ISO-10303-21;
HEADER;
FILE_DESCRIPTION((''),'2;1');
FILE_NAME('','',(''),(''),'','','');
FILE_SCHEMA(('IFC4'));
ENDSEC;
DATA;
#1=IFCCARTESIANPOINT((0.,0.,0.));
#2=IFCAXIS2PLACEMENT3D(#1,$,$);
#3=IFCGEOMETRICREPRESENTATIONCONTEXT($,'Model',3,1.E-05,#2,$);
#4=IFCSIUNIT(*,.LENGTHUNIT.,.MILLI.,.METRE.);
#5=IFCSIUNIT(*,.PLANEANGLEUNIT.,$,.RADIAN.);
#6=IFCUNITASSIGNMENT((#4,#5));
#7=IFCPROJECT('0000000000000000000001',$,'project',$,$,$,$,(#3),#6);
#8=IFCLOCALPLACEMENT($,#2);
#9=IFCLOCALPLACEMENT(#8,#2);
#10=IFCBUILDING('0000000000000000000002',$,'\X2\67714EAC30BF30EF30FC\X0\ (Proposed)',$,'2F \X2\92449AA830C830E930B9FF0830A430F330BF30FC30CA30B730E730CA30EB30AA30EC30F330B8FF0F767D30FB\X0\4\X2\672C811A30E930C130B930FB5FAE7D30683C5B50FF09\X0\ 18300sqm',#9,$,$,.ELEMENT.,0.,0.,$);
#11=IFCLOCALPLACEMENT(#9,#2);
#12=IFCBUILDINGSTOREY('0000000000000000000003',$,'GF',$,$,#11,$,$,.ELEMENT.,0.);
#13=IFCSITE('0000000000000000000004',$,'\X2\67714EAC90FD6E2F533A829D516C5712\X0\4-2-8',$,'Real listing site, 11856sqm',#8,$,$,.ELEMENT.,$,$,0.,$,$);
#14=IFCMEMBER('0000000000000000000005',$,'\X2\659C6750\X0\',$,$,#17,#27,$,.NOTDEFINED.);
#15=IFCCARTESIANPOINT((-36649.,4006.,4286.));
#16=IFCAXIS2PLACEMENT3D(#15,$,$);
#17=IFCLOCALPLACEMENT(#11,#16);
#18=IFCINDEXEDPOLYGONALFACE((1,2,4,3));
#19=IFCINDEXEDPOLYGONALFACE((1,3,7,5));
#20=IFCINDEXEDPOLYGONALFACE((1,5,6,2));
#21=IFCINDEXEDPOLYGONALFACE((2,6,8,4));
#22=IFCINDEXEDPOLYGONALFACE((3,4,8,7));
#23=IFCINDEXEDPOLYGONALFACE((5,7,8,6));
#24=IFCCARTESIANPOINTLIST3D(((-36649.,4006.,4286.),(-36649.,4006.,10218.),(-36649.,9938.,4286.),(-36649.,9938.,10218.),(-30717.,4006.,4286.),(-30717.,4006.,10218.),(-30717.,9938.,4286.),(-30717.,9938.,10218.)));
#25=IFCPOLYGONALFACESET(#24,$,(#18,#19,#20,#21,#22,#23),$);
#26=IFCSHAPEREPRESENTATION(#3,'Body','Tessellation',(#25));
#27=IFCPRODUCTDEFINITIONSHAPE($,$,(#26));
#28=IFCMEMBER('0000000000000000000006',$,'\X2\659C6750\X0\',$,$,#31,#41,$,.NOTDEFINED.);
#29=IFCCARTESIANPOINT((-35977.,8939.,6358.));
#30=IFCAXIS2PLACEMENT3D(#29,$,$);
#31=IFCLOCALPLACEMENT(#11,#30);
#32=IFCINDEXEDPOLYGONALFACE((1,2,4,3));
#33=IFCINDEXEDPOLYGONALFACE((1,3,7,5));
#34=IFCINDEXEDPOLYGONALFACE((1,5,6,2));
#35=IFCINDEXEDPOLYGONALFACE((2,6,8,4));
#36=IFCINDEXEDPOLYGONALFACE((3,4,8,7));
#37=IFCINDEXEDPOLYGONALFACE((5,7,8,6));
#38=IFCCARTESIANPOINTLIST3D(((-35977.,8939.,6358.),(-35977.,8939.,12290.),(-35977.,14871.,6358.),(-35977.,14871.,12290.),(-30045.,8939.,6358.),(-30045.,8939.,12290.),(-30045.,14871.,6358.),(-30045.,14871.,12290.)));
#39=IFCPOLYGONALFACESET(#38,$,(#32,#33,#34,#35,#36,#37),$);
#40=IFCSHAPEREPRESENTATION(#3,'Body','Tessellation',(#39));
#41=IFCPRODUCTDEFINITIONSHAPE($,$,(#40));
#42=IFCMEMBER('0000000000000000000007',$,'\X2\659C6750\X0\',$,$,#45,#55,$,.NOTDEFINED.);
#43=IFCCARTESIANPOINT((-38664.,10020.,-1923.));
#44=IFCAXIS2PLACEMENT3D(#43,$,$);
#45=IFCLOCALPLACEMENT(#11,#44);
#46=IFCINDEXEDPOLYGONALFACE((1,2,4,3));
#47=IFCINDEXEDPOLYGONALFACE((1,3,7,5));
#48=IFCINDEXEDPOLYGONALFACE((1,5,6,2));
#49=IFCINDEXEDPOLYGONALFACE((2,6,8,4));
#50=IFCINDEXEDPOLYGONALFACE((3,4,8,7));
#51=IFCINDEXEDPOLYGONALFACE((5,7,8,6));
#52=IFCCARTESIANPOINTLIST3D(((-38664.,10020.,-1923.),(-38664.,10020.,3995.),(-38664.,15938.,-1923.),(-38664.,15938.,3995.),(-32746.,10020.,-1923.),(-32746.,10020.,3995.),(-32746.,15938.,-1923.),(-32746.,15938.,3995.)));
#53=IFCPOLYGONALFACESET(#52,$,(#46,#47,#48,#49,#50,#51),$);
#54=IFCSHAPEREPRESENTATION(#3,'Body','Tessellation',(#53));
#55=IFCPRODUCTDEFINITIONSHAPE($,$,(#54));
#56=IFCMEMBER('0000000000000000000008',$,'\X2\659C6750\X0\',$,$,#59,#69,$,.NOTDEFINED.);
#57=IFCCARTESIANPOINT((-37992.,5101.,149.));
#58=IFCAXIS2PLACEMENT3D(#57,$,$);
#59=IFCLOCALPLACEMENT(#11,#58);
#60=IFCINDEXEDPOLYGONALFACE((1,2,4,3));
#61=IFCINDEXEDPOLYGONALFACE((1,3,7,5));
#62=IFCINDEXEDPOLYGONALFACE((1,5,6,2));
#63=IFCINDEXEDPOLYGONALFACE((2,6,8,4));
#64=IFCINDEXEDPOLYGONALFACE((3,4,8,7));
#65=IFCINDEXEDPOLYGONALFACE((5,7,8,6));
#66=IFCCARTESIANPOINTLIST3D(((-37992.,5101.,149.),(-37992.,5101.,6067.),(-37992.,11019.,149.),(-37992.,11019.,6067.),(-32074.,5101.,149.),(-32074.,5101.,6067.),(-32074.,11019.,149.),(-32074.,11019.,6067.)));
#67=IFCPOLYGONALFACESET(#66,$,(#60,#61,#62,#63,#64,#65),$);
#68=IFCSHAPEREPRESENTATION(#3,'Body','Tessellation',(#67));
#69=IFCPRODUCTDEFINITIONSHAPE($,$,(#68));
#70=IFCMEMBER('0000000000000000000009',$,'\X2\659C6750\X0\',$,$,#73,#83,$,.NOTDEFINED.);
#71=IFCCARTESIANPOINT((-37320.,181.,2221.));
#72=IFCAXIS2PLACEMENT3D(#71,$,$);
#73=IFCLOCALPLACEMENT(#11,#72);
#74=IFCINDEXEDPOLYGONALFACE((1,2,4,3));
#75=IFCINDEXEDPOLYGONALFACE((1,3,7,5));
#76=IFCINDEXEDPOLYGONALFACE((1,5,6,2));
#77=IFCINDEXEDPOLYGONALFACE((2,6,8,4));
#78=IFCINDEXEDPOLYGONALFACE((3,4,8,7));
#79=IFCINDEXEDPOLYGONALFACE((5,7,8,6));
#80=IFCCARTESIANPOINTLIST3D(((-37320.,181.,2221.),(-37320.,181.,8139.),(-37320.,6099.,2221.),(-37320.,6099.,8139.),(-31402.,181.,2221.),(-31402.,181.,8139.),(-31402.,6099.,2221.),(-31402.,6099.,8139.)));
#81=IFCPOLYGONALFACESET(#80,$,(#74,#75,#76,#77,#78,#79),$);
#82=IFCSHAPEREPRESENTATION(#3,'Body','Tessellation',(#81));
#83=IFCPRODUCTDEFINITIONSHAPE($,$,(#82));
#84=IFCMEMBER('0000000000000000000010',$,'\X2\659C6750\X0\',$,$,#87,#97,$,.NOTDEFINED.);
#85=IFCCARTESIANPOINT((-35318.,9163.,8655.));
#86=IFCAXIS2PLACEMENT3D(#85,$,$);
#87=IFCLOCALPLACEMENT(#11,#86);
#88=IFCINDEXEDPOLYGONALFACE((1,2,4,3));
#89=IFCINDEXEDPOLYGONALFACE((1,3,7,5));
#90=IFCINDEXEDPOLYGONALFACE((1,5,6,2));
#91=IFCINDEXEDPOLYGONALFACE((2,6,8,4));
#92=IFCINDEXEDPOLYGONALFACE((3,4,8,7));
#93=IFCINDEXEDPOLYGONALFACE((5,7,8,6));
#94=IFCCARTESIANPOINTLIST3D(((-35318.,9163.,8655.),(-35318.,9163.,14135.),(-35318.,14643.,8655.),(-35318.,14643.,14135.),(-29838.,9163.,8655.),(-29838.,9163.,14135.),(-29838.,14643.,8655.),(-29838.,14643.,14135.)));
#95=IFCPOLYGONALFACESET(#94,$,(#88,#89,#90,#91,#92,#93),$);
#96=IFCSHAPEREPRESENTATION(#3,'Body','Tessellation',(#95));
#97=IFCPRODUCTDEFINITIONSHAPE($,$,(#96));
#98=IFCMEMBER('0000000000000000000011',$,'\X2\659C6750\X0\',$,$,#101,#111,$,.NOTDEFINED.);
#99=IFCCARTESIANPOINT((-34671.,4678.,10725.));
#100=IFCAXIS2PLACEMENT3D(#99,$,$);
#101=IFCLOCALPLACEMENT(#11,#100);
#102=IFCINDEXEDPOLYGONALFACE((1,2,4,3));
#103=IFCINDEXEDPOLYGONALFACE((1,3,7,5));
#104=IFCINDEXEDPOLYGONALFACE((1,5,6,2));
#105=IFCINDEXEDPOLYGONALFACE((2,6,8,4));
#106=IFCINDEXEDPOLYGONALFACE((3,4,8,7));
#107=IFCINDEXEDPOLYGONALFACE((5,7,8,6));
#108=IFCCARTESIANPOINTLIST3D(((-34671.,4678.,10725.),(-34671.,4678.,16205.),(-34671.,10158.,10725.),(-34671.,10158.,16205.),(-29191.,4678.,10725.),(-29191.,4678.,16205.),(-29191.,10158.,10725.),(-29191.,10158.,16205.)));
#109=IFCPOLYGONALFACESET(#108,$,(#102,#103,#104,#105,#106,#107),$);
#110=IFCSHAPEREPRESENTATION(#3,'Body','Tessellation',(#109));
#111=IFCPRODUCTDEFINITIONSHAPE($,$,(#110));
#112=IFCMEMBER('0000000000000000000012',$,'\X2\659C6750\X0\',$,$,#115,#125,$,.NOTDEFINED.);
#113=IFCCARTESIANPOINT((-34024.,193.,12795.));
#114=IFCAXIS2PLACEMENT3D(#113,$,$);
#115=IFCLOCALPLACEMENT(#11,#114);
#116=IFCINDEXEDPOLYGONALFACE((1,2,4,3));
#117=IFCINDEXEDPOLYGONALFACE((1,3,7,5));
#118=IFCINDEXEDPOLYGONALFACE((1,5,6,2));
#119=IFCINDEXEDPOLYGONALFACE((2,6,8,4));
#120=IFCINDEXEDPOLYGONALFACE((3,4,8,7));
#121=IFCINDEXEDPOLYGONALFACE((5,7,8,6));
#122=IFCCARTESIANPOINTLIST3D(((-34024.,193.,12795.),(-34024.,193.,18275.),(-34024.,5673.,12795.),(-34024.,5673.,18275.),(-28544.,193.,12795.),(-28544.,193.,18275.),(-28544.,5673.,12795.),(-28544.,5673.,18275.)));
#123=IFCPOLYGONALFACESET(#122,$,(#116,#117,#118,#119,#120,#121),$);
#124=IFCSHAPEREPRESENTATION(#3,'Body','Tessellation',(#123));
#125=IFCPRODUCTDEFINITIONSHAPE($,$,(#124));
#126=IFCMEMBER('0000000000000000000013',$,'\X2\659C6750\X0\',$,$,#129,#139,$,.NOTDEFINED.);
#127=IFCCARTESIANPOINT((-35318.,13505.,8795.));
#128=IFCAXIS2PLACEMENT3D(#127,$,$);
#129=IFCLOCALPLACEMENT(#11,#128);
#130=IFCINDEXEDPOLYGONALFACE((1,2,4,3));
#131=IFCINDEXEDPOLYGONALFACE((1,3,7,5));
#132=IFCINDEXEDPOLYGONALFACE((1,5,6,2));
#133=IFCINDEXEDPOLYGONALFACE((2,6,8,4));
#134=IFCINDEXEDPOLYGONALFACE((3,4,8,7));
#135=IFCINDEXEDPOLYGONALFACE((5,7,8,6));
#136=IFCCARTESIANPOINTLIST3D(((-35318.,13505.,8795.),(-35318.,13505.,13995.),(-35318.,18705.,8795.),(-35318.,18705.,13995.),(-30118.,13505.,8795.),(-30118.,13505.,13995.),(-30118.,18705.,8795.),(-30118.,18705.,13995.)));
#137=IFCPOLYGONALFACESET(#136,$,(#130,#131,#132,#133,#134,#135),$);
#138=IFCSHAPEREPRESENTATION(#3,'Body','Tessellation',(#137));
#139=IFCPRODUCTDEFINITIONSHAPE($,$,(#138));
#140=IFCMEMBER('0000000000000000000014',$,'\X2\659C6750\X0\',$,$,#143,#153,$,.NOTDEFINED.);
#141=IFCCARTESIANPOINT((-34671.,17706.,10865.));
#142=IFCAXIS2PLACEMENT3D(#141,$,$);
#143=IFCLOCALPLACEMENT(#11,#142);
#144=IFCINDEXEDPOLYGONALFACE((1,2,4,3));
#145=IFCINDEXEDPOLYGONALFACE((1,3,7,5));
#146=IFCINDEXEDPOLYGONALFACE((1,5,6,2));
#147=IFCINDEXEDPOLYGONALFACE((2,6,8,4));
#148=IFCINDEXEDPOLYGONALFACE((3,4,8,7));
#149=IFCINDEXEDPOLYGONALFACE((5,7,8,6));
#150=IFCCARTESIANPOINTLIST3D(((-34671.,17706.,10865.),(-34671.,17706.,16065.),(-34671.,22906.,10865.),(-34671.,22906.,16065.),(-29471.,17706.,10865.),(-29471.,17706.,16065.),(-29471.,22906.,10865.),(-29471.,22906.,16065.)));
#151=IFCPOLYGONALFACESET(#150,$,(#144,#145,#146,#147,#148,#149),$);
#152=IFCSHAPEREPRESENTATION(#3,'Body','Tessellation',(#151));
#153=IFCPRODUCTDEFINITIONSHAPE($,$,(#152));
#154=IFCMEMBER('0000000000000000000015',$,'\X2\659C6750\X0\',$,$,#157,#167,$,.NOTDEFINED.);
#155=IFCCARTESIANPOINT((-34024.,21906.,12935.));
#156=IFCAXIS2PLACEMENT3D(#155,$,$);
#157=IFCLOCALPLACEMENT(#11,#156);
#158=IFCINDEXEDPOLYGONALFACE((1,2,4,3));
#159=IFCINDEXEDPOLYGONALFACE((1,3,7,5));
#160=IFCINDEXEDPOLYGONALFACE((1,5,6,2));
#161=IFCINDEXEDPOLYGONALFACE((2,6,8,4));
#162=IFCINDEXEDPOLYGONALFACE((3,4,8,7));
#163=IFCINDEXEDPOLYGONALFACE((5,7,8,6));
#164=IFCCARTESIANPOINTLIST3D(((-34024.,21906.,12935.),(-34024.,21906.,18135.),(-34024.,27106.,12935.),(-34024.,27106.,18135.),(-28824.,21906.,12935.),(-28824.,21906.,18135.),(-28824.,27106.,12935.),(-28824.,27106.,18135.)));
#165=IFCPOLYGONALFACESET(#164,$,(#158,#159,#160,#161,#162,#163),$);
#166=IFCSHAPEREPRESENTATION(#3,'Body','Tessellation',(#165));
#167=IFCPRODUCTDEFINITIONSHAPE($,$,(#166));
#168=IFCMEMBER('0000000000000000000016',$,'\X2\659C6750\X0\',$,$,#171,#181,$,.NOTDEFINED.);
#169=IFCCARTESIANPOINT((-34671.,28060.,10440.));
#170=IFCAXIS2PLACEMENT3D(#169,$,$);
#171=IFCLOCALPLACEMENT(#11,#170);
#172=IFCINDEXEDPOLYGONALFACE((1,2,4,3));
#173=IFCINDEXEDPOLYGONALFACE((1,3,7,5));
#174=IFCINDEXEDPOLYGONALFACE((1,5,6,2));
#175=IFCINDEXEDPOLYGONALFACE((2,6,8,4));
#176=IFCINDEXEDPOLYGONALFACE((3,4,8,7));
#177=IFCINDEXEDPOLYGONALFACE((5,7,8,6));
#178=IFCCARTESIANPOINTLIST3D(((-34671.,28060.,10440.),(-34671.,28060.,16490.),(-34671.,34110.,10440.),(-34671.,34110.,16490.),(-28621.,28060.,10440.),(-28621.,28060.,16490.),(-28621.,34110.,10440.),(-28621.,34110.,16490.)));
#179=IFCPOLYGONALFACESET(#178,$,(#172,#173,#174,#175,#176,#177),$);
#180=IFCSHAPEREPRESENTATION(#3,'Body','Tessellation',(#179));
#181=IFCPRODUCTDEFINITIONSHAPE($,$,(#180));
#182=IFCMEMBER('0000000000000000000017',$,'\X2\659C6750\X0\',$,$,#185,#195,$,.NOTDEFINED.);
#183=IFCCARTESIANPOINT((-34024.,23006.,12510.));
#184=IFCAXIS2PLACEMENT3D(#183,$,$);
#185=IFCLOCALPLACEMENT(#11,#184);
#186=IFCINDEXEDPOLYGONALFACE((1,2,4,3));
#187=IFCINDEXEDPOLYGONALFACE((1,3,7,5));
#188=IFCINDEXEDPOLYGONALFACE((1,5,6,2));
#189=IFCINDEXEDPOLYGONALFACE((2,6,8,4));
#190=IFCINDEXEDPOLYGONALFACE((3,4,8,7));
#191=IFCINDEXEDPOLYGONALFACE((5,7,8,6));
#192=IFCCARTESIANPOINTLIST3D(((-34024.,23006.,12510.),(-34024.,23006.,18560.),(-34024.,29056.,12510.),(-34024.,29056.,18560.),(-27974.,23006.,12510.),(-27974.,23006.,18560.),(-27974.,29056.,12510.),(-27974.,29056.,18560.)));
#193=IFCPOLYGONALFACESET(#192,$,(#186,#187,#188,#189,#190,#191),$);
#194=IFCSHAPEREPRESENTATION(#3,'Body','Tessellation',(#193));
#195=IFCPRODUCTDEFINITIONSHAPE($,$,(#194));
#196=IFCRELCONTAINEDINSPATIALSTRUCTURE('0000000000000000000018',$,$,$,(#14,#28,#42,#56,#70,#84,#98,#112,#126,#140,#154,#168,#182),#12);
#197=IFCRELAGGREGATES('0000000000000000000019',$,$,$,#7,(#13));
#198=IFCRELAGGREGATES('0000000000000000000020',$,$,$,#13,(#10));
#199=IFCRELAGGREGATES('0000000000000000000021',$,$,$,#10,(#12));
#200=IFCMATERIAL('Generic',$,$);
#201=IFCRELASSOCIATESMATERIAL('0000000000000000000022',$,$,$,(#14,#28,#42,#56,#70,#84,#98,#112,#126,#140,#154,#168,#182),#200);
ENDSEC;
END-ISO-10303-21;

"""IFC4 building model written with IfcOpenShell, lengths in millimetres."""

from ifc_helpers import new_model, si_unit, frame, frame_2d, origin, place, context, project, spatial, rectangle, extrude, material, element, save


model = new_model("IFC4")

# Units and contexts
model_context = context("Model", 3, precision=1e-05, world=origin())
ifc_project = project(units=[si_unit("LENGTHUNIT", "METRE", prefix="MILLI"), si_unit("PLANEANGLEUNIT", "RADIAN")], contexts=[model_context])

# Site, building, storey
site_placement = place(None, origin())
site = spatial("IfcSite", under=ifc_project, at=site_placement, Name="東京都港区芝公園4-2-8", ObjectType="Real listing site, 11856sqm", CompositionType="ELEMENT", RefElevation=0.0)
building_placement = place(site_placement, origin())
building = spatial("IfcBuilding", under=site, at=building_placement, Name="東京タワー (Proposed)", ObjectType="2F 鉄骨トラス（インターナショナルオレンジ／白・4本脚ラチス・微細格子） 18300sqm", CompositionType="ELEMENT", ElevationOfRefHeight=0.0, ElevationOfTerrain=0.0)
storey_placement = place(building_placement, origin())
storey = spatial("IfcBuildingStorey", under=building, at=storey_placement, Name="GF", CompositionType="ELEMENT", Elevation=0.0)

# Shared definitions
ifc_material = material(Name="Generic")

# Members
member_1_placement = place(storey_placement, frame((-36649.0, 4006.0, 4286.0)))
element("IfcMember", 1, at=member_1_placement, inside=storey, material=ifc_material, Name="斜材", PredefinedType="NOTDEFINED", context=model_context, shape_type="SweptSolid", body=[
    extrude(rectangle(XDim=5932.0, YDim=5932.0, at=frame_2d((2966.0, 2966.0))), frame((-36649.0, 4006.0, 4286.0)), (0.0, 0.0, 1.0), 5932.0),
])
member_2_placement = place(storey_placement, frame((-35977.0, 8939.0, 6358.0)))
element("IfcMember", 2, at=member_2_placement, inside=storey, material=ifc_material, Name="斜材", PredefinedType="NOTDEFINED", context=model_context, shape_type="SweptSolid", body=[
    extrude(rectangle(XDim=5932.0, YDim=5932.0, at=frame_2d((2966.0, 2966.0))), frame((-35977.0, 8939.0, 6358.0)), (0.0, 0.0, 1.0), 5932.0),
])
member_3_placement = place(storey_placement, frame((-38664.0, 10020.0, -1923.0)))
element("IfcMember", 3, at=member_3_placement, inside=storey, material=ifc_material, Name="斜材", PredefinedType="NOTDEFINED", context=model_context, shape_type="SweptSolid", body=[
    extrude(rectangle(XDim=5918.0, YDim=5918.0, at=frame_2d((2959.0, 2959.0))), frame((-38664.0, 10020.0, -1923.0)), (0.0, 0.0, 1.0), 5918.0),
])
member_4_placement = place(storey_placement, frame((-37992.0, 5101.0, 149.0)))
element("IfcMember", 4, at=member_4_placement, inside=storey, material=ifc_material, Name="斜材", PredefinedType="NOTDEFINED", context=model_context, shape_type="SweptSolid", body=[
    extrude(rectangle(XDim=5918.0, YDim=5918.0, at=frame_2d((2959.0, 2959.0))), frame((-37992.0, 5101.0, 149.0)), (0.0, 0.0, 1.0), 5918.0),
])
member_5_placement = place(storey_placement, frame((-37320.0, 181.0, 2221.0)))
element("IfcMember", 5, at=member_5_placement, inside=storey, material=ifc_material, Name="斜材", PredefinedType="NOTDEFINED", context=model_context, shape_type="SweptSolid", body=[
    extrude(rectangle(XDim=5918.0, YDim=5918.0, at=frame_2d((2959.0, 2959.0))), frame((-37320.0, 181.0, 2221.0)), (0.0, 0.0, 1.0), 5918.0),
])
member_6_placement = place(storey_placement, frame((-35318.0, 9163.0, 8655.0)))
element("IfcMember", 6, at=member_6_placement, inside=storey, material=ifc_material, Name="斜材", PredefinedType="NOTDEFINED", context=model_context, shape_type="SweptSolid", body=[
    extrude(rectangle(XDim=5480.0, YDim=5480.0, at=frame_2d((2740.0, 2740.0))), frame((-35318.0, 9163.0, 8655.0)), (0.0, 0.0, 1.0), 5480.0),
])
member_7_placement = place(storey_placement, frame((-34671.0, 4678.0, 10725.0)))
element("IfcMember", 7, at=member_7_placement, inside=storey, material=ifc_material, Name="斜材", PredefinedType="NOTDEFINED", context=model_context, shape_type="SweptSolid", body=[
    extrude(rectangle(XDim=5480.0, YDim=5480.0, at=frame_2d((2740.0, 2740.0))), frame((-34671.0, 4678.0, 10725.0)), (0.0, 0.0, 1.0), 5480.0),
])
member_8_placement = place(storey_placement, frame((-34024.0, 193.0, 12795.0)))
element("IfcMember", 8, at=member_8_placement, inside=storey, material=ifc_material, Name="斜材", PredefinedType="NOTDEFINED", context=model_context, shape_type="SweptSolid", body=[
    extrude(rectangle(XDim=5480.0, YDim=5480.0, at=frame_2d((2740.0, 2740.0))), frame((-34024.0, 193.0, 12795.0)), (0.0, 0.0, 1.0), 5480.0),
])
member_9_placement = place(storey_placement, frame((-35318.0, 13505.0, 8795.0)))
element("IfcMember", 9, at=member_9_placement, inside=storey, material=ifc_material, Name="斜材", PredefinedType="NOTDEFINED", context=model_context, shape_type="SweptSolid", body=[
    extrude(rectangle(XDim=5200.0, YDim=5200.0, at=frame_2d((2600.0, 2600.0))), frame((-35318.0, 13505.0, 8795.0)), (0.0, 0.0, 1.0), 5200.0),
])
member_10_placement = place(storey_placement, frame((-34671.0, 17706.0, 10865.0)))
element("IfcMember", 10, at=member_10_placement, inside=storey, material=ifc_material, Name="斜材", PredefinedType="NOTDEFINED", context=model_context, shape_type="SweptSolid", body=[
    extrude(rectangle(XDim=5200.0, YDim=5200.0, at=frame_2d((2600.0, 2600.0))), frame((-34671.0, 17706.0, 10865.0)), (0.0, 0.0, 1.0), 5200.0),
])
member_11_placement = place(storey_placement, frame((-34024.0, 21906.0, 12935.0)))
element("IfcMember", 11, at=member_11_placement, inside=storey, material=ifc_material, Name="斜材", PredefinedType="NOTDEFINED", context=model_context, shape_type="SweptSolid", body=[
    extrude(rectangle(XDim=5200.0, YDim=5200.0, at=frame_2d((2600.0, 2600.0))), frame((-34024.0, 21906.0, 12935.0)), (0.0, 0.0, 1.0), 5200.0),
])
member_12_placement = place(storey_placement, frame((-34671.0, 28060.0, 10440.0)))
element("IfcMember", 12, at=member_12_placement, inside=storey, material=ifc_material, Name="斜材", PredefinedType="NOTDEFINED", context=model_context, shape_type="SweptSolid", body=[
    extrude(rectangle(XDim=6050.0, YDim=6050.0, at=frame_2d((3025.0, 3025.0))), frame((-34671.0, 28060.0, 10440.0)), (0.0, 0.0, 1.0), 6050.0),
])
member_13_placement = place(storey_placement, frame((-34024.0, 23006.0, 12510.0)))
element("IfcMember", 13, at=member_13_placement, inside=storey, material=ifc_material, Name="斜材", PredefinedType="NOTDEFINED", context=model_context, shape_type="SweptSolid", body=[
    extrude(rectangle(XDim=6050.0, YDim=6050.0, at=frame_2d((3025.0, 3025.0))), frame((-34024.0, 23006.0, 12510.0)), (0.0, 0.0, 1.0), 6050.0),
])

save(model, "model.ifc")
